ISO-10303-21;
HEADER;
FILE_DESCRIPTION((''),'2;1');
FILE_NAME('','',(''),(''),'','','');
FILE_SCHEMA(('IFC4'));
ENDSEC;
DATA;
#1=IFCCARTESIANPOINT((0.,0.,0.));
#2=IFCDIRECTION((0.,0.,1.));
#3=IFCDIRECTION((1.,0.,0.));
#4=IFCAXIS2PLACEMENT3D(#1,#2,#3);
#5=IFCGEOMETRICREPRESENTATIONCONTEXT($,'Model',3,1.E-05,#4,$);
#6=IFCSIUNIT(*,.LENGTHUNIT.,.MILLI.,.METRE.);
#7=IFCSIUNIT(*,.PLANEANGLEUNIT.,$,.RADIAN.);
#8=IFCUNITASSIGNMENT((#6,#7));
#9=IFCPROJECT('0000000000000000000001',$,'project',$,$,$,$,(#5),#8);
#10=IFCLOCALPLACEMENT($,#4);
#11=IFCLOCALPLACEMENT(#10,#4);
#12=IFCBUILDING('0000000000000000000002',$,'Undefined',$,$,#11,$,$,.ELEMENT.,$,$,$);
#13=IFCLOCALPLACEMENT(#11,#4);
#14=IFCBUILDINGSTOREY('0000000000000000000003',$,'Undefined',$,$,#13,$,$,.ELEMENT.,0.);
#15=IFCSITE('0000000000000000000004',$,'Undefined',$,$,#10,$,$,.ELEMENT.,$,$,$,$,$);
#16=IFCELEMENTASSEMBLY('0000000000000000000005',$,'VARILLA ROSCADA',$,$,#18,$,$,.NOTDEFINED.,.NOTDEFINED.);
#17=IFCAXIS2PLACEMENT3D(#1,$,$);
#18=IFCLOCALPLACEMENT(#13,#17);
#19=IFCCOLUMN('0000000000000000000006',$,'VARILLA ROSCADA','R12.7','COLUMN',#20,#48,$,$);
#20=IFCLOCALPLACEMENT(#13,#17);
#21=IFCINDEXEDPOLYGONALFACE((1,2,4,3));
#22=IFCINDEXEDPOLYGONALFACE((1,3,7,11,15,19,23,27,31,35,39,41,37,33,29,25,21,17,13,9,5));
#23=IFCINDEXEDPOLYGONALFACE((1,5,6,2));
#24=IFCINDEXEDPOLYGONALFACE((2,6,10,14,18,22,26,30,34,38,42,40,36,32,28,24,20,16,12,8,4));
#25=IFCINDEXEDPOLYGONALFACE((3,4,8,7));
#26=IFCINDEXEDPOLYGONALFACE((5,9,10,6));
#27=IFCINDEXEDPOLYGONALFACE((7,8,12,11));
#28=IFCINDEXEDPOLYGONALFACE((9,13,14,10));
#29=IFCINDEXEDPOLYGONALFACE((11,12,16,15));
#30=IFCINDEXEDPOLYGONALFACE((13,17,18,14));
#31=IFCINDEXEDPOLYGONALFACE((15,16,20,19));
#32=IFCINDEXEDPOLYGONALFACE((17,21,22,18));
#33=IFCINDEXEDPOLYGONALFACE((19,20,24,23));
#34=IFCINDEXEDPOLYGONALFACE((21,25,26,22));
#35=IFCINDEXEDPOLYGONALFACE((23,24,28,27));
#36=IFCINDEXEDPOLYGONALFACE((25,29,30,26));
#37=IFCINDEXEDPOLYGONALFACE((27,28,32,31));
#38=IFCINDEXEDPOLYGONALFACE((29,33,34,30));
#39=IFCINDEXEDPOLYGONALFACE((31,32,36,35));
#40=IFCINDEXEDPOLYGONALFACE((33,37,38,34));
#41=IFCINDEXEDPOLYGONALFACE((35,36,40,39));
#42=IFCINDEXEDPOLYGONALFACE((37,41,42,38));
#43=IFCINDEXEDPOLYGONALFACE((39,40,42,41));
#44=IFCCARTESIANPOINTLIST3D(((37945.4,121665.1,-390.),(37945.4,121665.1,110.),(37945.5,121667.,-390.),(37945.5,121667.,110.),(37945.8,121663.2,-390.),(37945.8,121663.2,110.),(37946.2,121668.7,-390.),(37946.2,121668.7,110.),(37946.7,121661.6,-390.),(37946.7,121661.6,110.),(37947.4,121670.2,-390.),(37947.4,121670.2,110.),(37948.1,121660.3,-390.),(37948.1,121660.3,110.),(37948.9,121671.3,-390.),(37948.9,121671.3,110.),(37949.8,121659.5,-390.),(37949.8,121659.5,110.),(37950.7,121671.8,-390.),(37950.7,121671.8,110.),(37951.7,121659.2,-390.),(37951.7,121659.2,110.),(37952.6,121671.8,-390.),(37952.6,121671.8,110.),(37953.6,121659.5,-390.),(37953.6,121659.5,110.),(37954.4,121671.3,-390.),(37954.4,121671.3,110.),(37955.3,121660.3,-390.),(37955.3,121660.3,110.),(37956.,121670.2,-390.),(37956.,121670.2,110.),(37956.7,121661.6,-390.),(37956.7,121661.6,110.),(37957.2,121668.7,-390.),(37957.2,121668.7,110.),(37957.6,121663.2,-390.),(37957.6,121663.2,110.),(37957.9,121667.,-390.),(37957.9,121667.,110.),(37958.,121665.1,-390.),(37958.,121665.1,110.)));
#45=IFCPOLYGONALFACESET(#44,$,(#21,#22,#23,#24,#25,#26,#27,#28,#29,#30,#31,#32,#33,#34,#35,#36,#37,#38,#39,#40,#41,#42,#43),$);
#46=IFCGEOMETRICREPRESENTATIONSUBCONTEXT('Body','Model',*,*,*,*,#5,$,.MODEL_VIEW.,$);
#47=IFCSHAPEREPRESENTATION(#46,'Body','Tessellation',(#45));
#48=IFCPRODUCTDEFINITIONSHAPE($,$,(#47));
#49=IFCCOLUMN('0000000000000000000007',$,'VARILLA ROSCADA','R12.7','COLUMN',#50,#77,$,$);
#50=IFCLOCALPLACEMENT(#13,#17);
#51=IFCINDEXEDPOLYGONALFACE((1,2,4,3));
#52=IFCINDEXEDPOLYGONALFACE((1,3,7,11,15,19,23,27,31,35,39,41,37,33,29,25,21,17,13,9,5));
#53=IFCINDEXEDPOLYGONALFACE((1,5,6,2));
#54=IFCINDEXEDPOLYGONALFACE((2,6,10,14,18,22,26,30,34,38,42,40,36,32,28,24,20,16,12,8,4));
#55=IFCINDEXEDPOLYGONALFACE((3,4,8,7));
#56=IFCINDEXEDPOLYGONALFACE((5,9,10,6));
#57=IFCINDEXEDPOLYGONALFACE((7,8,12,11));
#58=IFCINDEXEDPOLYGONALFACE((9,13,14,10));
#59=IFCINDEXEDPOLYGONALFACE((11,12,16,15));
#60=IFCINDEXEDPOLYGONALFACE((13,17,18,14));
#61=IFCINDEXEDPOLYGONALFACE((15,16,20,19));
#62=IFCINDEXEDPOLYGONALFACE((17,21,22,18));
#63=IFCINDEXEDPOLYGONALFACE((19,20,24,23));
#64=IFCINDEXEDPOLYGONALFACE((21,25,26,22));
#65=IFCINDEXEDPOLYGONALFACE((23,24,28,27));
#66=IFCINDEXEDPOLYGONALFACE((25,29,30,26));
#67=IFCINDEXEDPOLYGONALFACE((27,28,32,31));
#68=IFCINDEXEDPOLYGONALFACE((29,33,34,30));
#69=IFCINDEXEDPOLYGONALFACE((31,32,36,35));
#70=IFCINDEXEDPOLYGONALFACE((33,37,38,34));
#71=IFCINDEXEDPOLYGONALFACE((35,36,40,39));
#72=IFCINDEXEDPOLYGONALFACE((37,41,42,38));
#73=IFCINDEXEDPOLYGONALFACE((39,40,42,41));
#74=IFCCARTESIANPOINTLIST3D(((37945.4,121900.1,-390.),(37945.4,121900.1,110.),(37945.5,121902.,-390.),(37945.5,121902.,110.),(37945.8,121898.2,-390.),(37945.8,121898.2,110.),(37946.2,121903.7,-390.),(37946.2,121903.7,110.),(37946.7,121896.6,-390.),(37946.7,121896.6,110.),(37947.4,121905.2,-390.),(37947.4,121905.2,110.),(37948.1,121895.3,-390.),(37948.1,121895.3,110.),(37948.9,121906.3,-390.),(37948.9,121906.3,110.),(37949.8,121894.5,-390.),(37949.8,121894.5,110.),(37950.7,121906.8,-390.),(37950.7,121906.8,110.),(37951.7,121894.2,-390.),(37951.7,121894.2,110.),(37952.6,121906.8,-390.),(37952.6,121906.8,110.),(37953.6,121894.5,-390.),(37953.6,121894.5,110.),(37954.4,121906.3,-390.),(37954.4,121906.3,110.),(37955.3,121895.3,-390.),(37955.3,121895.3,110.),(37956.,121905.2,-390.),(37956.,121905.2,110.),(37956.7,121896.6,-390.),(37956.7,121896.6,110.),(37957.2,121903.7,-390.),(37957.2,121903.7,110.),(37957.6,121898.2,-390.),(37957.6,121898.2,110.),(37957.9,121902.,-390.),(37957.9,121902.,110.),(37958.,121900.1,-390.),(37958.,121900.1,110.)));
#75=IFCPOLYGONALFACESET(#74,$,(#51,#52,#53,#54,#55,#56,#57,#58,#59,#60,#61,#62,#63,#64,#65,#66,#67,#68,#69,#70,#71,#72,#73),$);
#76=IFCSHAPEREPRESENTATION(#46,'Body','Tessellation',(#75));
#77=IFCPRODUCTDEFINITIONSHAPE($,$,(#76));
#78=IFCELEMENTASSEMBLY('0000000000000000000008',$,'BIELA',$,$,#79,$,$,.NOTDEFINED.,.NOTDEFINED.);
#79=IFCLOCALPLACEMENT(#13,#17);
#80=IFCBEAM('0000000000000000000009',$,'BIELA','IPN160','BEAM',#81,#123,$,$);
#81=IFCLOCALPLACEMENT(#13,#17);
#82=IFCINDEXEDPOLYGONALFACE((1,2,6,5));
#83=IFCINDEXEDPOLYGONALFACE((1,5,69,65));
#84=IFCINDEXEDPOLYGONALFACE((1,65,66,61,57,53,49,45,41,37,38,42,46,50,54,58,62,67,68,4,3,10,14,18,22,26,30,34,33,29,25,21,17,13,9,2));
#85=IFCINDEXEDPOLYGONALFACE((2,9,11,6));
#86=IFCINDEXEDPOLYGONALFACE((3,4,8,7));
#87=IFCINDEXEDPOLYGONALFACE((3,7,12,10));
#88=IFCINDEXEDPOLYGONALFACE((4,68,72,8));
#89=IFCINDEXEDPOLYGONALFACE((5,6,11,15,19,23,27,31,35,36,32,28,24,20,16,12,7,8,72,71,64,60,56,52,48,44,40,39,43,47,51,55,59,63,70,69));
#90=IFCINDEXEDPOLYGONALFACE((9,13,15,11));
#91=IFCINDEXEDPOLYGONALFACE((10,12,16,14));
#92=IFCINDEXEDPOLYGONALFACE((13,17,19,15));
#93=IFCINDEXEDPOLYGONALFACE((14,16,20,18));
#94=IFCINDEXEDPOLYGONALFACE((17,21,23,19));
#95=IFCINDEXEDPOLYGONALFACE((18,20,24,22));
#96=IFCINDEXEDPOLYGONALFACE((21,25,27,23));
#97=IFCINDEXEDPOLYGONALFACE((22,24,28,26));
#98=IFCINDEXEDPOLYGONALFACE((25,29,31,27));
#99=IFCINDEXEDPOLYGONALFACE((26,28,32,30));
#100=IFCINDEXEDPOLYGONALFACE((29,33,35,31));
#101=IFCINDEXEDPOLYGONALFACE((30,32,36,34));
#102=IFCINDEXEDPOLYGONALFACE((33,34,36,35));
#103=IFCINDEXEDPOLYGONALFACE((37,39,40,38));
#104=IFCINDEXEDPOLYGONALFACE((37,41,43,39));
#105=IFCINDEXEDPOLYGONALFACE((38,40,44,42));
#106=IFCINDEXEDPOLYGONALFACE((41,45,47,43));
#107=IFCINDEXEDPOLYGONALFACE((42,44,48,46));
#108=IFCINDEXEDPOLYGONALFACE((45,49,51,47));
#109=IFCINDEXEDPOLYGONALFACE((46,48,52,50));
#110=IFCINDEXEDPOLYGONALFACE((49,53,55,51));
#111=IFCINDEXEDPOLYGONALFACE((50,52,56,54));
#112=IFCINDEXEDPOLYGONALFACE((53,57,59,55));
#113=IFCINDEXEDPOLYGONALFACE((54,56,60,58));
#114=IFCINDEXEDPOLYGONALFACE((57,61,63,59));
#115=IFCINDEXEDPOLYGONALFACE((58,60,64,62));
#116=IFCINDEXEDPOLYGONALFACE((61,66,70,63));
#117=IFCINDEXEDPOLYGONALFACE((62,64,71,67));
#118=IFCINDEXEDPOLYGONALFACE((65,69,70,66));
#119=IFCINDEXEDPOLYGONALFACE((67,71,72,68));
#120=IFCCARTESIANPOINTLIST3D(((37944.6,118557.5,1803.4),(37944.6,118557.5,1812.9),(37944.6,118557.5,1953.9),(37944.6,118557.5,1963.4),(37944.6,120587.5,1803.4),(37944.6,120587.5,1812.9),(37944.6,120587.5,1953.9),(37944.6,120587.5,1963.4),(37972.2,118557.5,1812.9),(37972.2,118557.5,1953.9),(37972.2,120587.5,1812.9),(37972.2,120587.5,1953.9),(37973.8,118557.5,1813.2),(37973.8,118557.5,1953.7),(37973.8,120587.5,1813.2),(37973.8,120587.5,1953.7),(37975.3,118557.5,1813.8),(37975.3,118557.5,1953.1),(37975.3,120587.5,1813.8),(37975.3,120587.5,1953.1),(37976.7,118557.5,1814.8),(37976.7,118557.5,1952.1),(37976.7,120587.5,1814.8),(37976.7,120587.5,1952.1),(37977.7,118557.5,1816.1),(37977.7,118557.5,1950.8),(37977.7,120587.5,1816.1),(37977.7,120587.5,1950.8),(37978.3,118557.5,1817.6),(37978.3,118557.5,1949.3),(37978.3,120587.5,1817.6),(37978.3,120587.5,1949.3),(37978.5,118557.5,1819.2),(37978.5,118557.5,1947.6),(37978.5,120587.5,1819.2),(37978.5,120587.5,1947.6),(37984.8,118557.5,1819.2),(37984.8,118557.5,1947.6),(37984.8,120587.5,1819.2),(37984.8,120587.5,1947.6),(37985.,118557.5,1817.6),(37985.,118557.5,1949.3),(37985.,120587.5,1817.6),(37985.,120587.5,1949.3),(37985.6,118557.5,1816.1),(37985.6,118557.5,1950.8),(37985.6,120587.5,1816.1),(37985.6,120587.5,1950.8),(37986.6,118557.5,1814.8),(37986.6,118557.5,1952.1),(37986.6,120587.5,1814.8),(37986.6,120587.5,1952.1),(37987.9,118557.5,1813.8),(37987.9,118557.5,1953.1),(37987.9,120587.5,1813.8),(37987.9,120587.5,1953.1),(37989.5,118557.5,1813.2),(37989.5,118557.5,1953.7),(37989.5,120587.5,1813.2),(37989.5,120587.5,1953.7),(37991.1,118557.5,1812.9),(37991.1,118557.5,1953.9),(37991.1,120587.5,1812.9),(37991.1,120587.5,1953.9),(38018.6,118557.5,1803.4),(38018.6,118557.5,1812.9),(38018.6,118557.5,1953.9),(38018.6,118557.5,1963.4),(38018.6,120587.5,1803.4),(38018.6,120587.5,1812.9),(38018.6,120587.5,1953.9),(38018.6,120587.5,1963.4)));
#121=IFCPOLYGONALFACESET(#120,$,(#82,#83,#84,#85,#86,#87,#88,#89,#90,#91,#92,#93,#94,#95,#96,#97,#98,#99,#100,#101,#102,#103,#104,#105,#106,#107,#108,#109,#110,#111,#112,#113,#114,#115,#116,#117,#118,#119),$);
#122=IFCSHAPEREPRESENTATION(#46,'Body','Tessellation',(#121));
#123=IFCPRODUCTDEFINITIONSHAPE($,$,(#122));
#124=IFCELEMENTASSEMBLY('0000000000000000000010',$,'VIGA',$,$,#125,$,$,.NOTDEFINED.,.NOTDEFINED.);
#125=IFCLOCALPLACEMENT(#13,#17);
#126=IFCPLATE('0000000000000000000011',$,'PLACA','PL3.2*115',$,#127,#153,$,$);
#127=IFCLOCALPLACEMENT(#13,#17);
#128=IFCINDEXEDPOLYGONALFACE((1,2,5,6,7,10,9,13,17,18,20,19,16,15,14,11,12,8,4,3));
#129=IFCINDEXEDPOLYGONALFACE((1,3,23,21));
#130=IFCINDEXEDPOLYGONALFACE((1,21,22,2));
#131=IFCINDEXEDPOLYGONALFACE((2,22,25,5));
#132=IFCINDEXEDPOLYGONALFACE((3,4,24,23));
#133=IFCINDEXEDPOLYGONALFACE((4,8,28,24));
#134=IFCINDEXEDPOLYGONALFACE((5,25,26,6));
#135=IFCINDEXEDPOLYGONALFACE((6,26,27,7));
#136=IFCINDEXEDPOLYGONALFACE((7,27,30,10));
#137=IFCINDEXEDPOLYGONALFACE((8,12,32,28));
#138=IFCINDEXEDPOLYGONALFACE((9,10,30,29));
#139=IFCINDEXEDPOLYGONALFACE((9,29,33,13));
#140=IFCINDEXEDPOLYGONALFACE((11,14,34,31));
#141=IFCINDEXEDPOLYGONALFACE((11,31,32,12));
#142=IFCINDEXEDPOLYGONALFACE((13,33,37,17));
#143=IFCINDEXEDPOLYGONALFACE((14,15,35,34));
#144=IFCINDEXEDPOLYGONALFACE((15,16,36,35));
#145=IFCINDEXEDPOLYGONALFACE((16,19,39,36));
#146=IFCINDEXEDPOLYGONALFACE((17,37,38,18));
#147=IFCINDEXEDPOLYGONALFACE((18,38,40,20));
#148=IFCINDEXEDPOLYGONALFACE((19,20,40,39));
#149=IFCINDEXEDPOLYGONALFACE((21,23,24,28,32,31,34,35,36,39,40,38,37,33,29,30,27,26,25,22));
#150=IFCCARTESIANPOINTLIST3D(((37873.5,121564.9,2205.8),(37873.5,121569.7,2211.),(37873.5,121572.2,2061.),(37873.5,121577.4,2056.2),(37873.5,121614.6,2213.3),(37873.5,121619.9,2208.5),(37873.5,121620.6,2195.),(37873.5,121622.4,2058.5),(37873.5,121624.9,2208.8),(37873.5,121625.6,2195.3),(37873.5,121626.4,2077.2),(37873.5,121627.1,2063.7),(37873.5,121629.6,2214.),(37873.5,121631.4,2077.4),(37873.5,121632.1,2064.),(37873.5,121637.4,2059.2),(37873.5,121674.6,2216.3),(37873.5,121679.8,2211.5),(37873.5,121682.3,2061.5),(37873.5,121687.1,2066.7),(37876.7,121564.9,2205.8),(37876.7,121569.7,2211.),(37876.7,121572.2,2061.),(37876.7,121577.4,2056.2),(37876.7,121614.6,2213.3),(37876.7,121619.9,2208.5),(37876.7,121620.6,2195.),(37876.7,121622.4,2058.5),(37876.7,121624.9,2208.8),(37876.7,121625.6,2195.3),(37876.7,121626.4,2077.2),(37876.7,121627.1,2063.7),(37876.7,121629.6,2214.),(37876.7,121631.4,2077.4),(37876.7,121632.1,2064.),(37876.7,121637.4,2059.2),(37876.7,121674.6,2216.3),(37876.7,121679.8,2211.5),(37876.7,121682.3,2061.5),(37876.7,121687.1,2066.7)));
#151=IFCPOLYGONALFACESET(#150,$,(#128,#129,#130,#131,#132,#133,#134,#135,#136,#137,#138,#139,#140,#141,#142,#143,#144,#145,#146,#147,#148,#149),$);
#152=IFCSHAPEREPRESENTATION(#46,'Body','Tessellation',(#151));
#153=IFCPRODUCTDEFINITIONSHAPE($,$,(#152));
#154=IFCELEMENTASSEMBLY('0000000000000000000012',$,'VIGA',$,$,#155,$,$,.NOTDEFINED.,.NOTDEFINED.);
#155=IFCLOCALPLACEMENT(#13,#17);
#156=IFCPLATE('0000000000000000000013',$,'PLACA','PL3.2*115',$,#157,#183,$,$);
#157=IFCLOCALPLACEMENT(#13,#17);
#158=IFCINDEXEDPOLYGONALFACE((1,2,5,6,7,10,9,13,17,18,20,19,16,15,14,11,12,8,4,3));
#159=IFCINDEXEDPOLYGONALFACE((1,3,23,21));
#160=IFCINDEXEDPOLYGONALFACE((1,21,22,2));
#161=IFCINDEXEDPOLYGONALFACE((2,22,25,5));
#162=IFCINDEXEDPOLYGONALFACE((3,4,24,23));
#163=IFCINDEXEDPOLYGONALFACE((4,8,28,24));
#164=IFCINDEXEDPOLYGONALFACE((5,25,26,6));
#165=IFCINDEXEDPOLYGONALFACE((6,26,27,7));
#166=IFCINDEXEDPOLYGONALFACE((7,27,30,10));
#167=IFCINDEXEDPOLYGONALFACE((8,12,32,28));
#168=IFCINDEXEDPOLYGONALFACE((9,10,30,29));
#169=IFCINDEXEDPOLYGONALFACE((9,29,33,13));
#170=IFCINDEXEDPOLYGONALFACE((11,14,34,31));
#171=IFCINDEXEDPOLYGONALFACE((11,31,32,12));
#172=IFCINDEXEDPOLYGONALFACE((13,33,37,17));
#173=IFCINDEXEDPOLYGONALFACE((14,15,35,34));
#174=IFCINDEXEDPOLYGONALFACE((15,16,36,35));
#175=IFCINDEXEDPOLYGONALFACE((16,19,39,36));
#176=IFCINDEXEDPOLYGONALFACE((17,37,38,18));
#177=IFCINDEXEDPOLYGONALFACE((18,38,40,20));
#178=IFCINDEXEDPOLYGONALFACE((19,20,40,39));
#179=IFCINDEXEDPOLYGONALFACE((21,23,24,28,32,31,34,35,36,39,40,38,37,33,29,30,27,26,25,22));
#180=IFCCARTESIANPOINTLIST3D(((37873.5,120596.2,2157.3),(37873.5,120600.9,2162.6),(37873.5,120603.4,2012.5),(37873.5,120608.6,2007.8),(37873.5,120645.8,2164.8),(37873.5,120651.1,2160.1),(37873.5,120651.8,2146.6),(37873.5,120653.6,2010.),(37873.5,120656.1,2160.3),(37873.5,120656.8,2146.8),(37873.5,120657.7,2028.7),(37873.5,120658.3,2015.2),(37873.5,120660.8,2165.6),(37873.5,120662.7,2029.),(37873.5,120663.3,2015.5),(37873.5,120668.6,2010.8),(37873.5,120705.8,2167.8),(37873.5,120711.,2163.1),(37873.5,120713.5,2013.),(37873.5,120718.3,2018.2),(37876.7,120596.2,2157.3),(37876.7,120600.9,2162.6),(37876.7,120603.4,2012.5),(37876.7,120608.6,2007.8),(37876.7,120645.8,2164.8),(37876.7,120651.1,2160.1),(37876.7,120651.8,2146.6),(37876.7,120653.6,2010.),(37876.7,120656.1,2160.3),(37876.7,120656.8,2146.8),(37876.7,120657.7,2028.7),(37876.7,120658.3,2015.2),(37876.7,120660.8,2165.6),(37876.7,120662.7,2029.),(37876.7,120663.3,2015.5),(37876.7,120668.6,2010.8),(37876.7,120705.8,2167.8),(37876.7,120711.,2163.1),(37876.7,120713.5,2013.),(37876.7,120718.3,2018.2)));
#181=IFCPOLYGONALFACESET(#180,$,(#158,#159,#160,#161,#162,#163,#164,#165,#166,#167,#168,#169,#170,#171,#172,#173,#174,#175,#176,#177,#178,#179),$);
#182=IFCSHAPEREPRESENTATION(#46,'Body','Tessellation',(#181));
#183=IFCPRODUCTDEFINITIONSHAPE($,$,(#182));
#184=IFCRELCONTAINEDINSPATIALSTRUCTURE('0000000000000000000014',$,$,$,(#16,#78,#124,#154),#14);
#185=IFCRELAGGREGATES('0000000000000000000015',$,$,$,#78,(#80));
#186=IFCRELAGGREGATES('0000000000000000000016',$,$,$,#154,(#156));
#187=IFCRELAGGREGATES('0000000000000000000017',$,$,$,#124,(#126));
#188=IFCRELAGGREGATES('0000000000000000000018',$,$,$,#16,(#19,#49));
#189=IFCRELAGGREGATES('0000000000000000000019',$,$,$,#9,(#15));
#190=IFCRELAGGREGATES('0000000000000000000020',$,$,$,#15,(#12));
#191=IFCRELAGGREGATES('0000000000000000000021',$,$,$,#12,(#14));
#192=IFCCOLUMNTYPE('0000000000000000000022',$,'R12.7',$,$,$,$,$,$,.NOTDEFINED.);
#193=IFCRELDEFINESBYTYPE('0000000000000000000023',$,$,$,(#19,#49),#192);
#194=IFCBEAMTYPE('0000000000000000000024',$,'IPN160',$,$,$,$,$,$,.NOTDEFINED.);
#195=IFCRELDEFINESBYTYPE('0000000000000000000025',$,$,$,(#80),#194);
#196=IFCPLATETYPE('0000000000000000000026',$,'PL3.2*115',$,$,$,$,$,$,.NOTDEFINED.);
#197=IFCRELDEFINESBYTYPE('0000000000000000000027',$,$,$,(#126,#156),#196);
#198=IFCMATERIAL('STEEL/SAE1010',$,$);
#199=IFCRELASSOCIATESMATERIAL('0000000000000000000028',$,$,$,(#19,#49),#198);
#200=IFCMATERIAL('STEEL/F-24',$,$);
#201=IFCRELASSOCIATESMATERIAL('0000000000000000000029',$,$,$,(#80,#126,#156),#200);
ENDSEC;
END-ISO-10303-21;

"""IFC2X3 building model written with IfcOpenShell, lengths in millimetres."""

from ifc_helpers import new_model, si_unit, frame, origin_with_axes, origin_2d_with_axis, place, context, subcontext, project, spatial, polyline, circle, i_section, outline, extrude, material, type_object, element, aggregate, save


model = new_model("IFC2X3")

# Units and contexts
model_context = context("Model", 3, precision=1e-05, world=origin_with_axes())
body_context = subcontext(model_context, "Body", "Model", "MODEL_VIEW")
ifc_project = project(units=[si_unit("LENGTHUNIT", "METRE", prefix="MILLI"), si_unit("PLANEANGLEUNIT", "RADIAN")], contexts=[model_context])

# Site, building, storey
site_placement = place(None, origin_with_axes())
site = spatial("IfcSite", under=ifc_project, at=site_placement, Name="Undefined", CompositionType="ELEMENT")
building_placement = place(site_placement, origin_with_axes())
building = spatial("IfcBuilding", under=site, at=building_placement, Name="Undefined", CompositionType="ELEMENT")
storey_placement = place(building_placement, origin_with_axes())
storey = spatial("IfcBuildingStorey", under=building, at=storey_placement, Name="Undefined", CompositionType="ELEMENT", Elevation=0.0)

# Element assembly, columns
assembly_1_placement = place(storey_placement, origin_with_axes())
assembly_1 = element("IfcElementAssembly", 1, at=assembly_1_placement, inside=storey, Name="VARILLA ROSCADA", AssemblyPlace="NOTDEFINED", PredefinedType="NOTDEFINED")
ifc_material_1 = material(Name="STEEL/SAE1010")
column_type = type_object("IfcColumnType", Name="R12.7", PredefinedType="NOTDEFINED")
column_1_placement = place(assembly_1_placement, frame((37951.7, 121665.6, -390.0), z_axis=(0.0, 0.0, 1.0), x_axis=(-1.0, 0.0, 0.0)))
column_1 = element("IfcColumn", 2, at=column_1_placement, type_object=column_type, material=ifc_material_1, Name="VARILLA ROSCADA", Description="R12.7", ObjectType="COLUMN", context=body_context, shape_type="SweptSolid", body=[
    extrude(circle(Radius=6.3, at=origin_2d_with_axis()), frame((0.0, 0.0, 500.0), z_axis=(0.0, 0.0, -1.0), x_axis=(0.0, 1.0, 0.0)), (0.0, 0.0, 1.0), 500.0),
])
column_2_placement = place(assembly_1_placement, frame((37951.7, 121900.6, -390.0), z_axis=(0.0, 0.0, 1.0), x_axis=(-1.0, 0.0, 0.0)))
column_2 = element("IfcColumn", 3, at=column_2_placement, type_object=column_type, material=ifc_material_1, Name="VARILLA ROSCADA", Description="R12.7", ObjectType="COLUMN", context=body_context, shape_type="SweptSolid", body=[
    extrude(circle(Radius=6.3, at=origin_2d_with_axis()), frame((0.0, 0.0, 500.0), z_axis=(0.0, 0.0, -1.0), x_axis=(0.0, 1.0, 0.0)), (0.0, 0.0, 1.0), 500.0),
])

# Element assembly, beam
assembly_2_placement = place(storey_placement, origin_with_axes())
assembly_2 = element("IfcElementAssembly", 4, at=assembly_2_placement, inside=storey, Name="BIELA", AssemblyPlace="NOTDEFINED", PredefinedType="NOTDEFINED")
ifc_material_2 = material(Name="STEEL/F-24")
beam_type = type_object("IfcBeamType", Name="IPN160", PredefinedType="NOTDEFINED")
beam_placement = place(assembly_2_placement, frame((37981.6, 120587.5, 1883.4), z_axis=(0.0, 0.000002, 1.0), x_axis=(0.0, -1.0, 0.000002)))
beam = element("IfcBeam", 5, at=beam_placement, type_object=beam_type, material=ifc_material_2, Name="BIELA", Description="IPN160", ObjectType="BEAM", context=body_context, shape_type="SweptSolid", body=[
    extrude(i_section(OverallWidth=74.0, OverallDepth=160.0, WebThickness=6.3, FlangeThickness=9.5, FilletRadius=6.3, at=origin_2d_with_axis()), frame((2030.0, 0.0, 0.0), z_axis=(-1.0, 0.0, 0.0), x_axis=(0.0, -1.0, 0.0)), (0.0, 0.0, 1.0), 2030.0),
])
aggregate(assembly_2, [beam])

# Element assemblies, plates
assembly_3_placement = place(storey_placement, origin_with_axes())
assembly_3 = element("IfcElementAssembly", 6, at=assembly_3_placement, inside=storey, Name="VIGA", AssemblyPlace="NOTDEFINED", PredefinedType="NOTDEFINED")
plate_type_1 = type_object("IfcPlateType", Name="PL3.2*115", PredefinedType="NOTDEFINED")
plate_1_placement = place(assembly_3_placement, frame((37875.1, 121564.7, 2210.8), z_axis=(-1.0, 0.0, 0.0), x_axis=(0.0, 0.998752, 0.04995)))
plate_1 = element("IfcPlate", 7, at=plate_1_placement, type_object=plate_type_1, material=ifc_material_2, Name="PLACA", Description="PL3.2*115", context=body_context, shape_type="SweptSolid", body=[
    extrude(outline(polyline([(0.0, 5.0), (5.0, 0.0), (50.0, 0.0), (55.0, 5.0), (55.0, 18.5), (60.0, 18.5), (60.0, 5.0), (65.0, 0.0), (110.0, 0.0), (115.0, 5.0), (115.0, 150.0), (110.0, 155.0), (65.0, 155.0), (60.0, 150.0), (60.0, 136.5), (55.0, 136.5), (55.0, 150.0), (50.0, 155.0), (5.0, 155.0), (0.0, 150.0), (0.0, 5.0)])), frame((0.0, 0.0, -1.6), z_axis=(0.0, 0.0, 1.0), x_axis=(1.0, 0.0, 0.0)), (0.0, 0.0, 1.0), 3.2),
])
assembly_4_placement = place(storey_placement, origin_with_axes())
assembly_4 = element("IfcElementAssembly", 8, at=assembly_4_placement, inside=storey, Name="VIGA", AssemblyPlace="NOTDEFINED", PredefinedType="NOTDEFINED")
plate_2_placement = place(assembly_4_placement, frame((37875.1, 120595.9, 2162.3), z_axis=(-1.0, 0.0, 0.0), x_axis=(0.0, 0.998752, 0.04995)))
plate_2 = element("IfcPlate", 9, at=plate_2_placement, type_object=plate_type_1, material=ifc_material_2, Name="PLACA", Description="PL3.2*115", context=body_context, shape_type="SweptSolid", body=[
    extrude(outline(polyline([(0.0, 5.0), (5.0, 0.0), (50.0, 0.0), (55.0, 5.0), (55.0, 18.5), (60.0, 18.5), (60.0, 5.0), (65.0, 0.0), (110.0, 0.0), (115.0, 5.0), (115.0, 150.0), (110.0, 155.0), (65.0, 155.0), (60.0, 150.0), (60.0, 136.5), (55.0, 136.5), (55.0, 150.0), (50.0, 155.0), (5.0, 155.0), (0.0, 150.0), (0.0, 5.0)])), frame((0.0, 0.0, -1.6), z_axis=(0.0, 0.0, 1.0), x_axis=(1.0, 0.0, 0.0)), (0.0, 0.0, 1.0), 3.2),
])

aggregate(assembly_4, [plate_2])
aggregate(assembly_3, [plate_1])
aggregate(assembly_1, [column_1, column_2])

save(model, "model.ifc")
